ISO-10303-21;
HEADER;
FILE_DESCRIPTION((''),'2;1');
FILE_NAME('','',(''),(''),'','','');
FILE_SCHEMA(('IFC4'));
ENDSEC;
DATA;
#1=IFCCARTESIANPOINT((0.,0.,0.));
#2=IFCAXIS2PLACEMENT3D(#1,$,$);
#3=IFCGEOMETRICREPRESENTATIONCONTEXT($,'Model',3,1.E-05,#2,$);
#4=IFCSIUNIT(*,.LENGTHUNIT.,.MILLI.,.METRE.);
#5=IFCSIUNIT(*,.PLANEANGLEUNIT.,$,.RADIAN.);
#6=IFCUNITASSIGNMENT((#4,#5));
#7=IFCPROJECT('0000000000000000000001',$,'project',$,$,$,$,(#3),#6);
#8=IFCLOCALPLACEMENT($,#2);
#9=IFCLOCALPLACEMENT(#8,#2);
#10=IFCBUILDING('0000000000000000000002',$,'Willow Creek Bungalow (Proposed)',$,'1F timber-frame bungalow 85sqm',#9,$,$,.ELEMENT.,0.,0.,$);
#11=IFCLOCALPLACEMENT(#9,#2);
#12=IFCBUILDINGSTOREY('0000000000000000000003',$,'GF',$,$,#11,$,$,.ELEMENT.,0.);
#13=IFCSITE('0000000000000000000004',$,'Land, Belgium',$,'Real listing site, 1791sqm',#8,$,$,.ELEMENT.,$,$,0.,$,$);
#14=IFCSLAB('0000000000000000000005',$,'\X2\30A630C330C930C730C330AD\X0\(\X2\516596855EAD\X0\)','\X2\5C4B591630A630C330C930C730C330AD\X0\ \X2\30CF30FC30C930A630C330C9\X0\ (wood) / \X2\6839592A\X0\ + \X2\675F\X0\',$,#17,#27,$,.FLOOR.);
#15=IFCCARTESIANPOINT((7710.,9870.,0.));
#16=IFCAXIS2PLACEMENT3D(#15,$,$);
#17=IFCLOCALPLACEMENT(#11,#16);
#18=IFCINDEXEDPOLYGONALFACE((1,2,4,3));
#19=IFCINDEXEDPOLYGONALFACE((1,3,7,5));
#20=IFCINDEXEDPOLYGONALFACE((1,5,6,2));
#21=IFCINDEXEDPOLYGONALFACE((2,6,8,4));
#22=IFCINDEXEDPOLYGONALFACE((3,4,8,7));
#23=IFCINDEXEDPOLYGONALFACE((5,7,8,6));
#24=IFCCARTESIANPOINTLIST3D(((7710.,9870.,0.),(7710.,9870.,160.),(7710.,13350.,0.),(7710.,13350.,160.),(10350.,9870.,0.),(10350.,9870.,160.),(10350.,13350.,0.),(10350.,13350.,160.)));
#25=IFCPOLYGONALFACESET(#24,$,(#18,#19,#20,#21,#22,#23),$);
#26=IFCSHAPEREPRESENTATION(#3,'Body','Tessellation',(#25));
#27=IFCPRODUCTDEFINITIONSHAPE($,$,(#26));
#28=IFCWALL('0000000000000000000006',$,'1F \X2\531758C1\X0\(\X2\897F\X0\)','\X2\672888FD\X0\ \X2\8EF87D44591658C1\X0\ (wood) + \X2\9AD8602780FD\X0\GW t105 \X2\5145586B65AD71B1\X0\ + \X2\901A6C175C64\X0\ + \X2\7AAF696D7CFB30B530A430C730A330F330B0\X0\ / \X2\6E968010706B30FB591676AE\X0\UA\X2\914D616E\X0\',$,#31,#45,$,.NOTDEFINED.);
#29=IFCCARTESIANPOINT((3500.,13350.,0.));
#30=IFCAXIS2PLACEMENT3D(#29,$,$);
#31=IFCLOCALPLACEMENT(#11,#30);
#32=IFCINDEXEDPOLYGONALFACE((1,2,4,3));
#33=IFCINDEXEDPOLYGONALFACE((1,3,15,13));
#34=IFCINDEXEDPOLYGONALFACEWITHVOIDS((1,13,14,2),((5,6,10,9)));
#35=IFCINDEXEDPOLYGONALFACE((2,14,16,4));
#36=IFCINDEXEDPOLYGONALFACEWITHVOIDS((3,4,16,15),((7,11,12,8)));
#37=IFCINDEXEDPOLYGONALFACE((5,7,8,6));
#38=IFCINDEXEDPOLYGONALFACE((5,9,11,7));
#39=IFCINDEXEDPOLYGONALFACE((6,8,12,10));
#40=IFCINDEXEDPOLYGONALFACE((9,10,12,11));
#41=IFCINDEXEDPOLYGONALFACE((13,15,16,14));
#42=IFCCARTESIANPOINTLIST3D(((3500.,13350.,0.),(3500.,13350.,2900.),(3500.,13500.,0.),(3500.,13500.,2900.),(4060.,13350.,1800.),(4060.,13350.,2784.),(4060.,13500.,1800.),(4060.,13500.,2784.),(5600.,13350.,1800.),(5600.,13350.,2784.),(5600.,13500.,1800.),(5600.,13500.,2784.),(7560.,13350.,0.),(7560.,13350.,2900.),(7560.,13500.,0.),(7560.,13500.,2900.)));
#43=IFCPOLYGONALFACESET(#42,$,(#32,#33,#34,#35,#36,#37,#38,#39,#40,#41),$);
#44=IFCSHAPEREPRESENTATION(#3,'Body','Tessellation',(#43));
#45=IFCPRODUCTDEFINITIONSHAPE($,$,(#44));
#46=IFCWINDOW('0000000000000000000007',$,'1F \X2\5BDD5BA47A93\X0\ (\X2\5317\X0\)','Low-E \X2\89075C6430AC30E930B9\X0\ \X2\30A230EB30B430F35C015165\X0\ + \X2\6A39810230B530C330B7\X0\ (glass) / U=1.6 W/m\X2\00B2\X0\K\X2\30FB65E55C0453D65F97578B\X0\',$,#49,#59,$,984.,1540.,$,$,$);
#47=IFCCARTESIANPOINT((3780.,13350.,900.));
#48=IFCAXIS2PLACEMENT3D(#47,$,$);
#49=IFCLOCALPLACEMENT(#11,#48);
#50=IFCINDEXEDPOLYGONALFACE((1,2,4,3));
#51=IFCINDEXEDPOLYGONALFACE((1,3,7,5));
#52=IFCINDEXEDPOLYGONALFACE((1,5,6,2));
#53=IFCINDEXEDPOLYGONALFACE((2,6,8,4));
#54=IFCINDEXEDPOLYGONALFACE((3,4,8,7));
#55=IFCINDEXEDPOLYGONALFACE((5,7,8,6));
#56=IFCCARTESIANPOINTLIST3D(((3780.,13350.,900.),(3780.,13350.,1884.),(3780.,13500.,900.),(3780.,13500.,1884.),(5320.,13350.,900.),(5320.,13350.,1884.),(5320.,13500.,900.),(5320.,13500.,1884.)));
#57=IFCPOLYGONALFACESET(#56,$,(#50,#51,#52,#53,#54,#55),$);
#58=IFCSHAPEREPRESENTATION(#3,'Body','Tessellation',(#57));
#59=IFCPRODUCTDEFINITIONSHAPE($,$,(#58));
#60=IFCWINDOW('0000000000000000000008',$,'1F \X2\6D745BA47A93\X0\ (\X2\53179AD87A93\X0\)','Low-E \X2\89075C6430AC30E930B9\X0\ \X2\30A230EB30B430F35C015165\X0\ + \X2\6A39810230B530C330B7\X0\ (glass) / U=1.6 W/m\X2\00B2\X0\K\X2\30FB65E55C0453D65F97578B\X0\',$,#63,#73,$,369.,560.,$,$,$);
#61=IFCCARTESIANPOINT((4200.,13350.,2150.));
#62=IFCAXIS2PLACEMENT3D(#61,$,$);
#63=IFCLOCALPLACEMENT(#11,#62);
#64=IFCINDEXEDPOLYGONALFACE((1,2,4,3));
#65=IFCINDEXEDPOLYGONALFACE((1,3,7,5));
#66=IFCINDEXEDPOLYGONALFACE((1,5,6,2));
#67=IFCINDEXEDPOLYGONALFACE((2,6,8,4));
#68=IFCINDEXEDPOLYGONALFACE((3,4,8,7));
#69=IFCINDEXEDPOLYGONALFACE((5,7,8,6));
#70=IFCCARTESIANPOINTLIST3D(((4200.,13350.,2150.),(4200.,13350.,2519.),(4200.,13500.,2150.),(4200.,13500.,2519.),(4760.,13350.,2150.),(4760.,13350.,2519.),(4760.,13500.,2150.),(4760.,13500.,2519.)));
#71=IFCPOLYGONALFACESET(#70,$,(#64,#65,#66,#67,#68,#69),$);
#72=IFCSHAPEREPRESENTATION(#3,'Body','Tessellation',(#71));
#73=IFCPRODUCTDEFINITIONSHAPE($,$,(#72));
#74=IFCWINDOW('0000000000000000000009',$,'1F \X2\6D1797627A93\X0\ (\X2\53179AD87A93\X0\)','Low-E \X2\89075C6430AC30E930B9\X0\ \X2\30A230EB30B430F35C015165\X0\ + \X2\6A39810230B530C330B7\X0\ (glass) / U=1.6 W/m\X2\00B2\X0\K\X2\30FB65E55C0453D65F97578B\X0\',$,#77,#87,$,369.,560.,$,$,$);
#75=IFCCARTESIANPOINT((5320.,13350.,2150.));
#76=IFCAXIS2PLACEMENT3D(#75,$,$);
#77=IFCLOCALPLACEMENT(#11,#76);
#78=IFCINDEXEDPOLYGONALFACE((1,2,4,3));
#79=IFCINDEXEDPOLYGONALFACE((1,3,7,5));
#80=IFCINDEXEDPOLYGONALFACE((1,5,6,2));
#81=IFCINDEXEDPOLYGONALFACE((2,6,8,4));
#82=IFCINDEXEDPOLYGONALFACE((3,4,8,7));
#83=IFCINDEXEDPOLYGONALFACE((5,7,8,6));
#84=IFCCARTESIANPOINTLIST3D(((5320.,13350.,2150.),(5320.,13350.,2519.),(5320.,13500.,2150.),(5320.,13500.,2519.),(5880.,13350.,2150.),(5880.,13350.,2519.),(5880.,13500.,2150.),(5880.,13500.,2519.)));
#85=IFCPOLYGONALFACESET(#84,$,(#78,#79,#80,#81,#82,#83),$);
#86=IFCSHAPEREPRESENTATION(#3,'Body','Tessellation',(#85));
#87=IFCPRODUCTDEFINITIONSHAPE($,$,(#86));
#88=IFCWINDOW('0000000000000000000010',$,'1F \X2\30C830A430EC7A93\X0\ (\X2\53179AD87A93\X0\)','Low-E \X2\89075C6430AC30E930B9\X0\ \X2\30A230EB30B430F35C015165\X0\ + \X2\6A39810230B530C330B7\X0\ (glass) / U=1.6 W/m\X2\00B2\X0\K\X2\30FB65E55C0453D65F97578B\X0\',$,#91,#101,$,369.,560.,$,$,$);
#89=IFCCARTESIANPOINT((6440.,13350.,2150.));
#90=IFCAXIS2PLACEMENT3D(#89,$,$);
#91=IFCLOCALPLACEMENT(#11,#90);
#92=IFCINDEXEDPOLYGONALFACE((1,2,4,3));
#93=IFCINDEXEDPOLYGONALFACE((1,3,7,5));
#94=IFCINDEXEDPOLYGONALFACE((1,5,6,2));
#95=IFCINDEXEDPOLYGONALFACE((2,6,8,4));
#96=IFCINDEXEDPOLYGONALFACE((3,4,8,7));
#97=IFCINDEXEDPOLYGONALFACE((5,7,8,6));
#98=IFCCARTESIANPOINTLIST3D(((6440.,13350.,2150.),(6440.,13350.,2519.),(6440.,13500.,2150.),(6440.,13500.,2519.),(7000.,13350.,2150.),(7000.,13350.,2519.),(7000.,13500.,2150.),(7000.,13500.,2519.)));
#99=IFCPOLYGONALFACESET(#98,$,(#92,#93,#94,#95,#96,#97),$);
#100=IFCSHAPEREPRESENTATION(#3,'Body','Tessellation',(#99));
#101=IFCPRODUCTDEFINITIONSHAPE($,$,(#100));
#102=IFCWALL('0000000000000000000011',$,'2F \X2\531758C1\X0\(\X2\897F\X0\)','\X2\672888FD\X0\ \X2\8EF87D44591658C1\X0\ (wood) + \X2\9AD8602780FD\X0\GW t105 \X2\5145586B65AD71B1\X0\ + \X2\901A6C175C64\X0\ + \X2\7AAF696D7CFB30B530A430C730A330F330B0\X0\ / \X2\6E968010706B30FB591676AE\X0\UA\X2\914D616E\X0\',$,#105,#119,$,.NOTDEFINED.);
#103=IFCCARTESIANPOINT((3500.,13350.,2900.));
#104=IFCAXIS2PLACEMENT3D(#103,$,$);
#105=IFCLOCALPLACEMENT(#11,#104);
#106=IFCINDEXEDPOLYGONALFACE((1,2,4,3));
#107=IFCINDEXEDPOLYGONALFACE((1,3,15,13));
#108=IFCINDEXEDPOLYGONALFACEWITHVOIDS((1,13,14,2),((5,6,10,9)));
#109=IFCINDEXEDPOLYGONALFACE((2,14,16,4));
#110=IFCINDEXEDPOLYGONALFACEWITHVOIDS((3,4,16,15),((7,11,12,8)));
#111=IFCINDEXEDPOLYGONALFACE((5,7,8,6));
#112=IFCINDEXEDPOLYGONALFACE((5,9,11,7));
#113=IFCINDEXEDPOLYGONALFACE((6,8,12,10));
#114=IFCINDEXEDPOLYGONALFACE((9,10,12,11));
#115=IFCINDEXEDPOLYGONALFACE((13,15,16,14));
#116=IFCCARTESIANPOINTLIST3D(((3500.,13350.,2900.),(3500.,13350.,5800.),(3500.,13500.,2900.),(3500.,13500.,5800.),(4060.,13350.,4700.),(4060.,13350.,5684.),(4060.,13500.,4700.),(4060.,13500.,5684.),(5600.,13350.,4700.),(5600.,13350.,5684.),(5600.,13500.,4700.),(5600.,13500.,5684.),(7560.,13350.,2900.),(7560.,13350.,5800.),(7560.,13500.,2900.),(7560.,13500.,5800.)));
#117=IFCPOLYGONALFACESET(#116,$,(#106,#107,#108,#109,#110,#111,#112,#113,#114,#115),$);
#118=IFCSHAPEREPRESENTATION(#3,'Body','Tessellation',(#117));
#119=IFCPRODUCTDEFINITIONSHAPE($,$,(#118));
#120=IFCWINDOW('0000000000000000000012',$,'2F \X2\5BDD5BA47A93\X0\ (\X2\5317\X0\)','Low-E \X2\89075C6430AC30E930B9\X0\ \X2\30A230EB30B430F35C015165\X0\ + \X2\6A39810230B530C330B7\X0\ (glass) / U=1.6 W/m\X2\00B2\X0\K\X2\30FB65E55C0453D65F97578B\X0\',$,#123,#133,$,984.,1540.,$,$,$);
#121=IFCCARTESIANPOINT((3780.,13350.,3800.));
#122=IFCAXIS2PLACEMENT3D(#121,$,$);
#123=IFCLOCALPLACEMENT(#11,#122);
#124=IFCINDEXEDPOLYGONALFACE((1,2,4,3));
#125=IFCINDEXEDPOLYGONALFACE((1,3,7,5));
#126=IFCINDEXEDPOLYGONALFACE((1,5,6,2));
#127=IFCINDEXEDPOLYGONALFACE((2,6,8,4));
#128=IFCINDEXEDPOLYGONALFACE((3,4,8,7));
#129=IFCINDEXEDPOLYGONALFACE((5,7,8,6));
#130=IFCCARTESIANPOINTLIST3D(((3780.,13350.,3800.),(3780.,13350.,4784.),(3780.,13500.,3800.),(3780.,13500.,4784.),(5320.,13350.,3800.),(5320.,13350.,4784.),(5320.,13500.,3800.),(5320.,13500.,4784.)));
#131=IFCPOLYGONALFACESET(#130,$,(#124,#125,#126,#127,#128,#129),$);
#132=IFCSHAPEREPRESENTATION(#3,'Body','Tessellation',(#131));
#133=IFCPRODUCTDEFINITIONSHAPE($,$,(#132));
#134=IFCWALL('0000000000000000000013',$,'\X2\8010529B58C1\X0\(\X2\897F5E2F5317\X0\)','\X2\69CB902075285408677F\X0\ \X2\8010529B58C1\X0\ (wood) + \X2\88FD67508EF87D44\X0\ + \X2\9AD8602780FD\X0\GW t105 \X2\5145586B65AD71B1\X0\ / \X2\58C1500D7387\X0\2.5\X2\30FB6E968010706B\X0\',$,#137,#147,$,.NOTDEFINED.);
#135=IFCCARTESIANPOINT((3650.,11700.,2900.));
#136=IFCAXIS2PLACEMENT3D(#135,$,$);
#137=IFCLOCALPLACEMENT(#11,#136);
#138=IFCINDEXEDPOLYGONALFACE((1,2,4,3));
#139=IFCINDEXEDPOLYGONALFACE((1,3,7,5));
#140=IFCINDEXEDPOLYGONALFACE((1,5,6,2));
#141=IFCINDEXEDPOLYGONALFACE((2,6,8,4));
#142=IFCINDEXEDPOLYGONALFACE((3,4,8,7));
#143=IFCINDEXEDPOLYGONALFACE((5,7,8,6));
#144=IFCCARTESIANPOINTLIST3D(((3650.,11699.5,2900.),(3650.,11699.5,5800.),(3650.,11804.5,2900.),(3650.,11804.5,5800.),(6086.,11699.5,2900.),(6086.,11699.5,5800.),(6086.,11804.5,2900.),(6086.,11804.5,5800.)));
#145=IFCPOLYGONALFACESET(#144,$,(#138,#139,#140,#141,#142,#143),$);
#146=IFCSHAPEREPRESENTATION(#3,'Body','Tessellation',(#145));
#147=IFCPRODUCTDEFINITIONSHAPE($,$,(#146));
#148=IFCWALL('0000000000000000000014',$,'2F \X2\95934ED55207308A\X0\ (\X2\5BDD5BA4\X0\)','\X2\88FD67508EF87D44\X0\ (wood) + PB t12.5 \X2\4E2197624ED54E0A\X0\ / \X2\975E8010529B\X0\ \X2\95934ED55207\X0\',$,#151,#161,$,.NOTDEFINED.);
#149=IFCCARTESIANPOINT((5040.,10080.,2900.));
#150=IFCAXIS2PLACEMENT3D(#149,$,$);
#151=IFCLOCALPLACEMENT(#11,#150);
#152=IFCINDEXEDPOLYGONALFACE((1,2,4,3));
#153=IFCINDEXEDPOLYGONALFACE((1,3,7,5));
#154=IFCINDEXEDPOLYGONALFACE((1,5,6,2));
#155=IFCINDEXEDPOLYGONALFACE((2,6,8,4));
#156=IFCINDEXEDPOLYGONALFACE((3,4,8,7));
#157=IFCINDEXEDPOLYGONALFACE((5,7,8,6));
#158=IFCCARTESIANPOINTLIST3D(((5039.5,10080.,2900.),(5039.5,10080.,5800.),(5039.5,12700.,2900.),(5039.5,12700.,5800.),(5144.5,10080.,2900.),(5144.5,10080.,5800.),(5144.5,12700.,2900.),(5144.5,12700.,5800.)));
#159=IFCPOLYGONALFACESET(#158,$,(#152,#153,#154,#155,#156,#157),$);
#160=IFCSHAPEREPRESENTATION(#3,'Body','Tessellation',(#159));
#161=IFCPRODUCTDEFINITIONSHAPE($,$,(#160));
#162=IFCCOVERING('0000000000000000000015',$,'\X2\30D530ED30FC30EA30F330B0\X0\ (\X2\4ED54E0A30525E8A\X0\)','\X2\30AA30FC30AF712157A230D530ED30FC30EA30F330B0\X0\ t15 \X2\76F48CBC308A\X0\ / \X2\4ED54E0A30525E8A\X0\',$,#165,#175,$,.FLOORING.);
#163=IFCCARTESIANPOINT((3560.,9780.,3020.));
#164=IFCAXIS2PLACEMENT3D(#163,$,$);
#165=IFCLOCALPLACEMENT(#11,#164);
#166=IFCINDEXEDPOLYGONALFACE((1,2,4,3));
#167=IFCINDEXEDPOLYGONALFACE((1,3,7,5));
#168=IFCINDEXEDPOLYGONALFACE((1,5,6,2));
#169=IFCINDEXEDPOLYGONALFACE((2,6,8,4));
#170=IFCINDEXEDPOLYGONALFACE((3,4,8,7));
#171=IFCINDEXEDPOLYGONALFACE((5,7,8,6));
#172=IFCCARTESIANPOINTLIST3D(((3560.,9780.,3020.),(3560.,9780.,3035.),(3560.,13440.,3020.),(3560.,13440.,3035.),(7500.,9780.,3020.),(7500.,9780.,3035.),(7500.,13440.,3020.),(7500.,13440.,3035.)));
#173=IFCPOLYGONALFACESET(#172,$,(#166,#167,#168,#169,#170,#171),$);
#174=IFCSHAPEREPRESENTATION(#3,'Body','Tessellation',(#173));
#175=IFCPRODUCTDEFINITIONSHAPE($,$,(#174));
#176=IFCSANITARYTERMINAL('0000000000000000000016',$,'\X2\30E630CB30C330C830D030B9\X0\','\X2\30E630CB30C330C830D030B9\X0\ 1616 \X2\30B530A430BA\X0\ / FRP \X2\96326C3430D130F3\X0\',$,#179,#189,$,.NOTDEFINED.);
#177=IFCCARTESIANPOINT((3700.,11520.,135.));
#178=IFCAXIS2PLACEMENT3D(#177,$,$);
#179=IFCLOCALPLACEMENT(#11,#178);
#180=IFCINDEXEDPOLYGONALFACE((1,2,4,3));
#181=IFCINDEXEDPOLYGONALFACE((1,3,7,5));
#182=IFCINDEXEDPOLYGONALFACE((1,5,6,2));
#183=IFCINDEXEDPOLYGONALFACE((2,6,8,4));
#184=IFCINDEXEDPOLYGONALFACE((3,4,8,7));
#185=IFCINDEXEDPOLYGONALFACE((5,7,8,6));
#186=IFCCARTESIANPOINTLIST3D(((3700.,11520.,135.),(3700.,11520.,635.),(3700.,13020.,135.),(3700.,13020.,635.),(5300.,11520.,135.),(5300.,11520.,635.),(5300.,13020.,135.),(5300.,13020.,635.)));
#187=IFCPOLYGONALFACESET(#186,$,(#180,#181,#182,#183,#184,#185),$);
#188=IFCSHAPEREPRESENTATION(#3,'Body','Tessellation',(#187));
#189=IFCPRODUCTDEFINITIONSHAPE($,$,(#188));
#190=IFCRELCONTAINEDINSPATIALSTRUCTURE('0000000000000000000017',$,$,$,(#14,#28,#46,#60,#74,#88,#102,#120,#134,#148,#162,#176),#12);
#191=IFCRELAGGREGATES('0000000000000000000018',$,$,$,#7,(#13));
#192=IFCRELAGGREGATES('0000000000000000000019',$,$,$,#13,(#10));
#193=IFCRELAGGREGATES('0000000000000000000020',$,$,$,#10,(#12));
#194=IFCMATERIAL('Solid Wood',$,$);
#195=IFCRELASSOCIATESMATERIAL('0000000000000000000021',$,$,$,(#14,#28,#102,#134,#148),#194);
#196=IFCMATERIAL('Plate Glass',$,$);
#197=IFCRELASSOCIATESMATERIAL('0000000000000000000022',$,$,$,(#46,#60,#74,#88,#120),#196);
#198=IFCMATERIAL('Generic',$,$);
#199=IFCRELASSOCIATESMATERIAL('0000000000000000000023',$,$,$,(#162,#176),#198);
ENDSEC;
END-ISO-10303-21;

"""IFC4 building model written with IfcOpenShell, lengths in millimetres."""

from ifc_helpers import new_model, si_unit, frame, frame_2d, origin, place, context, project, spatial, rectangle, extrude, material, element, fill, save


model = new_model("IFC4")

# Units and contexts
model_context = context("Model", 3, precision=1e-05, world=origin())
ifc_project = project(units=[si_unit("LENGTHUNIT", "METRE", prefix="MILLI"), si_unit("PLANEANGLEUNIT", "RADIAN")], contexts=[model_context])

# Site, building, storey
site_placement = place(None, origin())
site = spatial("IfcSite", under=ifc_project, at=site_placement, Name="Land, Belgium", ObjectType="Real listing site, 1791sqm", CompositionType="ELEMENT", RefElevation=0.0)
building_placement = place(site_placement, origin())
building = spatial("IfcBuilding", under=site, at=building_placement, Name="Willow Creek Bungalow (Proposed)", ObjectType="1F timber-frame bungalow 85sqm", CompositionType="ELEMENT", ElevationOfRefHeight=0.0, ElevationOfTerrain=0.0)
storey_placement = place(building_placement, origin())
storey = spatial("IfcBuildingStorey", under=building, at=storey_placement, Name="GF", CompositionType="ELEMENT", Elevation=0.0)

# Slab
ifc_material_1 = material(Name="Solid Wood")
slab_placement = place(storey_placement, frame((7710.0, 9870.0, 0.0)))
element("IfcSlab", 1, at=slab_placement, inside=storey, material=ifc_material_1, Name="ウッドデッキ(入隅庭)", Description="屋外ウッドデッキ ハードウッド (wood) / 根太 + 束", PredefinedType="FLOOR", context=model_context, shape_type="SweptSolid", body=[
    extrude(rectangle(XDim=2640.0, YDim=3480.0, at=frame_2d((1320.0, 1740.0))), frame((7710.0, 9870.0, 0.0)), (0.0, 0.0, 1.0), 160.0),
])

# Wall, openings, windows
wall_1_placement = place(storey_placement, frame((3500.0, 13350.0, 0.0)))
wall_1 = element("IfcWall", 2, at=wall_1_placement, inside=storey, material=ifc_material_1, Name="1F 北壁(西)", Description="木製 軸組外壁 (wood) + 高性能GW t105 充填断熱 + 通気層 + 窯業系サイディング / 準耐火・外皮UA配慮", PredefinedType="NOTDEFINED", context=model_context, shape_type="SweptSolid", body=[
    extrude(rectangle(XDim=4060.0, YDim=150.0, at=frame_2d((2030.0, 75.0))), frame((3500.0, 13350.0, 0.0)), (0.0, 0.0, 1.0), 2900.0),
])
opening_1_placement = place(storey_placement, frame((3780.0, 13350.0, 900.0)))
opening_1 = element("IfcOpeningElement", 3, at=opening_1_placement, cuts=wall_1, PredefinedType="NOTDEFINED", context=model_context, shape_type="SweptSolid", body=[
    extrude(rectangle(XDim=1540.0, YDim=150.0, at=frame_2d((770.0, 75.0))), frame((3780.0, 13350.0, 900.0)), (0.0, 0.0, 1.0), 984.0),
])
opening_2_placement = place(storey_placement, frame((4200.0, 13350.0, 2150.0)))
opening_2 = element("IfcOpeningElement", 4, at=opening_2_placement, cuts=wall_1, PredefinedType="NOTDEFINED", context=model_context, shape_type="SweptSolid", body=[
    extrude(rectangle(XDim=560.0, YDim=150.0, at=frame_2d((280.0, 75.0))), frame((4200.0, 13350.0, 2150.0)), (0.0, 0.0, 1.0), 369.0),
])
opening_3_placement = place(storey_placement, frame((5320.0, 13350.0, 2150.0)))
opening_3 = element("IfcOpeningElement", 5, at=opening_3_placement, cuts=wall_1, PredefinedType="NOTDEFINED", context=model_context, shape_type="SweptSolid", body=[
    extrude(rectangle(XDim=560.0, YDim=150.0, at=frame_2d((280.0, 75.0))), frame((5320.0, 13350.0, 2150.0)), (0.0, 0.0, 1.0), 369.0),
])
opening_4_placement = place(storey_placement, frame((6440.0, 13350.0, 2150.0)))
opening_4 = element("IfcOpeningElement", 6, at=opening_4_placement, cuts=wall_1, PredefinedType="NOTDEFINED", context=model_context, shape_type="SweptSolid", body=[
    extrude(rectangle(XDim=560.0, YDim=150.0, at=frame_2d((280.0, 75.0))), frame((6440.0, 13350.0, 2150.0)), (0.0, 0.0, 1.0), 369.0),
])
ifc_material_2 = material(Name="Plate Glass")
window_1_placement = place(storey_placement, frame((3780.0, 13350.0, 900.0)))
window_1 = element("IfcWindow", 7, at=window_1_placement, inside=storey, material=ifc_material_2, Name="1F 寝室窓 (北)", Description="Low-E 複層ガラス アルゴン封入 + 樹脂サッシ (glass) / U=1.6 W/m²K・日射取得型", OverallHeight=984.0, OverallWidth=1540.0, context=model_context, shape_type="SweptSolid", body=[
    extrude(rectangle(XDim=1540.0, YDim=150.0, at=frame_2d((770.0, 75.0))), frame((3780.0, 13350.0, 900.0)), (0.0, 0.0, 1.0), 984.0),
])
fill(opening_1, window_1)
window_2_placement = place(storey_placement, frame((4200.0, 13350.0, 2150.0)))
window_2 = element("IfcWindow", 8, at=window_2_placement, inside=storey, material=ifc_material_2, Name="1F 浴室窓 (北高窓)", Description="Low-E 複層ガラス アルゴン封入 + 樹脂サッシ (glass) / U=1.6 W/m²K・日射取得型", OverallHeight=369.0, OverallWidth=560.0, context=model_context, shape_type="SweptSolid", body=[
    extrude(rectangle(XDim=560.0, YDim=150.0, at=frame_2d((280.0, 75.0))), frame((4200.0, 13350.0, 2150.0)), (0.0, 0.0, 1.0), 369.0),
])
fill(opening_2, window_2)
window_3_placement = place(storey_placement, frame((5320.0, 13350.0, 2150.0)))
window_3 = element("IfcWindow", 9, at=window_3_placement, inside=storey, material=ifc_material_2, Name="1F 洗面窓 (北高窓)", Description="Low-E 複層ガラス アルゴン封入 + 樹脂サッシ (glass) / U=1.6 W/m²K・日射取得型", OverallHeight=369.0, OverallWidth=560.0, context=model_context, shape_type="SweptSolid", body=[
    extrude(rectangle(XDim=560.0, YDim=150.0, at=frame_2d((280.0, 75.0))), frame((5320.0, 13350.0, 2150.0)), (0.0, 0.0, 1.0), 369.0),
])
fill(opening_3, window_3)
window_4_placement = place(storey_placement, frame((6440.0, 13350.0, 2150.0)))
window_4 = element("IfcWindow", 10, at=window_4_placement, inside=storey, material=ifc_material_2, Name="1F トイレ窓 (北高窓)", Description="Low-E 複層ガラス アルゴン封入 + 樹脂サッシ (glass) / U=1.6 W/m²K・日射取得型", OverallHeight=369.0, OverallWidth=560.0, context=model_context, shape_type="SweptSolid", body=[
    extrude(rectangle(XDim=560.0, YDim=150.0, at=frame_2d((280.0, 75.0))), frame((6440.0, 13350.0, 2150.0)), (0.0, 0.0, 1.0), 369.0),
])
fill(opening_4, window_4)

# Wall, opening, window
wall_2_placement = place(storey_placement, frame((3500.0, 13350.0, 2900.0)))
wall_2 = element("IfcWall", 11, at=wall_2_placement, inside=storey, material=ifc_material_1, Name="2F 北壁(西)", Description="木製 軸組外壁 (wood) + 高性能GW t105 充填断熱 + 通気層 + 窯業系サイディング / 準耐火・外皮UA配慮", PredefinedType="NOTDEFINED", context=model_context, shape_type="SweptSolid", body=[
    extrude(rectangle(XDim=4060.0, YDim=150.0, at=frame_2d((2030.0, 75.0))), frame((3500.0, 13350.0, 2900.0)), (0.0, 0.0, 1.0), 2900.0),
])
opening_5_placement = place(storey_placement, frame((3780.0, 13350.0, 3800.0)))
opening_5 = element("IfcOpeningElement", 12, at=opening_5_placement, cuts=wall_2, PredefinedType="NOTDEFINED", context=model_context, shape_type="SweptSolid", body=[
    extrude(rectangle(XDim=1540.0, YDim=150.0, at=frame_2d((770.0, 75.0))), frame((3780.0, 13350.0, 3800.0)), (0.0, 0.0, 1.0), 984.0),
])
window_5_placement = place(storey_placement, frame((3780.0, 13350.0, 3800.0)))
window_5 = element("IfcWindow", 13, at=window_5_placement, inside=storey, material=ifc_material_2, Name="2F 寝室窓 (北)", Description="Low-E 複層ガラス アルゴン封入 + 樹脂サッシ (glass) / U=1.6 W/m²K・日射取得型", OverallHeight=984.0, OverallWidth=1540.0, context=model_context, shape_type="SweptSolid", body=[
    extrude(rectangle(XDim=1540.0, YDim=150.0, at=frame_2d((770.0, 75.0))), frame((3780.0, 13350.0, 3800.0)), (0.0, 0.0, 1.0), 984.0),
])
fill(opening_5, window_5)

# Walls
wall_3_placement = place(storey_placement, frame((3650.0, 11700.0, 2900.0)))
element("IfcWall", 14, at=wall_3_placement, inside=storey, material=ifc_material_1, Name="耐力壁(西帯北)", Description="構造用合板 耐力壁 (wood) + 製材軸組 + 高性能GW t105 充填断熱 / 壁倍率2.5・準耐火", PredefinedType="NOTDEFINED", context=model_context, shape_type="SweptSolid", body=[
    extrude(rectangle(XDim=2436.0, YDim=105.0, at=frame_2d((1218.0, 52.0))), frame((3650.0, 11700.0, 2900.0)), (0.0, 0.0, 1.0), 2900.0),
])
wall_4_placement = place(storey_placement, frame((5040.0, 10080.0, 2900.0)))
element("IfcWall", 15, at=wall_4_placement, inside=storey, material=ifc_material_1, Name="2F 間仕切り (寝室)", Description="製材軸組 (wood) + PB t12.5 両面仕上 / 非耐力 間仕切", PredefinedType="NOTDEFINED", context=model_context, shape_type="SweptSolid", body=[
    extrude(rectangle(XDim=105.0, YDim=2620.0, at=frame_2d((52.0, 1310.0))), frame((5040.0, 10080.0, 2900.0)), (0.0, 0.0, 1.0), 2900.0),
])

# Covering
ifc_material_3 = material(Name="Generic")
covering_placement = place(storey_placement, frame((3560.0, 9780.0, 3020.0)))
element("IfcCovering", 16, at=covering_placement, inside=storey, material=ifc_material_3, Name="フローリング (仕上げ床)", Description="オーク無垢フローリング t15 直貼り / 仕上げ床", PredefinedType="FLOORING", context=model_context, shape_type="SweptSolid", body=[
    extrude(rectangle(XDim=3940.0, YDim=3660.0, at=frame_2d((1970.0, 1830.0))), frame((3560.0, 9780.0, 3020.0)), (0.0, 0.0, 1.0), 15.0),
])

# Sanitary terminal
sanitary_terminal_1_placement = place(storey_placement, frame((3700.0, 11520.0, 135.0)))
element("IfcSanitaryTerminal", 17, at=sanitary_terminal_1_placement, inside=storey, material=ifc_material_3, Name="ユニットバス", Description="ユニットバス 1616 サイズ / FRP 防水パン", PredefinedType="NOTDEFINED", context=model_context, shape_type="SweptSolid", body=[
    extrude(rectangle(XDim=1600.0, YDim=1500.0, at=frame_2d((800.0, 750.0))), frame((3700.0, 11520.0, 135.0)), (0.0, 0.0, 1.0), 500.0),
])

save(model, "model.ifc")
